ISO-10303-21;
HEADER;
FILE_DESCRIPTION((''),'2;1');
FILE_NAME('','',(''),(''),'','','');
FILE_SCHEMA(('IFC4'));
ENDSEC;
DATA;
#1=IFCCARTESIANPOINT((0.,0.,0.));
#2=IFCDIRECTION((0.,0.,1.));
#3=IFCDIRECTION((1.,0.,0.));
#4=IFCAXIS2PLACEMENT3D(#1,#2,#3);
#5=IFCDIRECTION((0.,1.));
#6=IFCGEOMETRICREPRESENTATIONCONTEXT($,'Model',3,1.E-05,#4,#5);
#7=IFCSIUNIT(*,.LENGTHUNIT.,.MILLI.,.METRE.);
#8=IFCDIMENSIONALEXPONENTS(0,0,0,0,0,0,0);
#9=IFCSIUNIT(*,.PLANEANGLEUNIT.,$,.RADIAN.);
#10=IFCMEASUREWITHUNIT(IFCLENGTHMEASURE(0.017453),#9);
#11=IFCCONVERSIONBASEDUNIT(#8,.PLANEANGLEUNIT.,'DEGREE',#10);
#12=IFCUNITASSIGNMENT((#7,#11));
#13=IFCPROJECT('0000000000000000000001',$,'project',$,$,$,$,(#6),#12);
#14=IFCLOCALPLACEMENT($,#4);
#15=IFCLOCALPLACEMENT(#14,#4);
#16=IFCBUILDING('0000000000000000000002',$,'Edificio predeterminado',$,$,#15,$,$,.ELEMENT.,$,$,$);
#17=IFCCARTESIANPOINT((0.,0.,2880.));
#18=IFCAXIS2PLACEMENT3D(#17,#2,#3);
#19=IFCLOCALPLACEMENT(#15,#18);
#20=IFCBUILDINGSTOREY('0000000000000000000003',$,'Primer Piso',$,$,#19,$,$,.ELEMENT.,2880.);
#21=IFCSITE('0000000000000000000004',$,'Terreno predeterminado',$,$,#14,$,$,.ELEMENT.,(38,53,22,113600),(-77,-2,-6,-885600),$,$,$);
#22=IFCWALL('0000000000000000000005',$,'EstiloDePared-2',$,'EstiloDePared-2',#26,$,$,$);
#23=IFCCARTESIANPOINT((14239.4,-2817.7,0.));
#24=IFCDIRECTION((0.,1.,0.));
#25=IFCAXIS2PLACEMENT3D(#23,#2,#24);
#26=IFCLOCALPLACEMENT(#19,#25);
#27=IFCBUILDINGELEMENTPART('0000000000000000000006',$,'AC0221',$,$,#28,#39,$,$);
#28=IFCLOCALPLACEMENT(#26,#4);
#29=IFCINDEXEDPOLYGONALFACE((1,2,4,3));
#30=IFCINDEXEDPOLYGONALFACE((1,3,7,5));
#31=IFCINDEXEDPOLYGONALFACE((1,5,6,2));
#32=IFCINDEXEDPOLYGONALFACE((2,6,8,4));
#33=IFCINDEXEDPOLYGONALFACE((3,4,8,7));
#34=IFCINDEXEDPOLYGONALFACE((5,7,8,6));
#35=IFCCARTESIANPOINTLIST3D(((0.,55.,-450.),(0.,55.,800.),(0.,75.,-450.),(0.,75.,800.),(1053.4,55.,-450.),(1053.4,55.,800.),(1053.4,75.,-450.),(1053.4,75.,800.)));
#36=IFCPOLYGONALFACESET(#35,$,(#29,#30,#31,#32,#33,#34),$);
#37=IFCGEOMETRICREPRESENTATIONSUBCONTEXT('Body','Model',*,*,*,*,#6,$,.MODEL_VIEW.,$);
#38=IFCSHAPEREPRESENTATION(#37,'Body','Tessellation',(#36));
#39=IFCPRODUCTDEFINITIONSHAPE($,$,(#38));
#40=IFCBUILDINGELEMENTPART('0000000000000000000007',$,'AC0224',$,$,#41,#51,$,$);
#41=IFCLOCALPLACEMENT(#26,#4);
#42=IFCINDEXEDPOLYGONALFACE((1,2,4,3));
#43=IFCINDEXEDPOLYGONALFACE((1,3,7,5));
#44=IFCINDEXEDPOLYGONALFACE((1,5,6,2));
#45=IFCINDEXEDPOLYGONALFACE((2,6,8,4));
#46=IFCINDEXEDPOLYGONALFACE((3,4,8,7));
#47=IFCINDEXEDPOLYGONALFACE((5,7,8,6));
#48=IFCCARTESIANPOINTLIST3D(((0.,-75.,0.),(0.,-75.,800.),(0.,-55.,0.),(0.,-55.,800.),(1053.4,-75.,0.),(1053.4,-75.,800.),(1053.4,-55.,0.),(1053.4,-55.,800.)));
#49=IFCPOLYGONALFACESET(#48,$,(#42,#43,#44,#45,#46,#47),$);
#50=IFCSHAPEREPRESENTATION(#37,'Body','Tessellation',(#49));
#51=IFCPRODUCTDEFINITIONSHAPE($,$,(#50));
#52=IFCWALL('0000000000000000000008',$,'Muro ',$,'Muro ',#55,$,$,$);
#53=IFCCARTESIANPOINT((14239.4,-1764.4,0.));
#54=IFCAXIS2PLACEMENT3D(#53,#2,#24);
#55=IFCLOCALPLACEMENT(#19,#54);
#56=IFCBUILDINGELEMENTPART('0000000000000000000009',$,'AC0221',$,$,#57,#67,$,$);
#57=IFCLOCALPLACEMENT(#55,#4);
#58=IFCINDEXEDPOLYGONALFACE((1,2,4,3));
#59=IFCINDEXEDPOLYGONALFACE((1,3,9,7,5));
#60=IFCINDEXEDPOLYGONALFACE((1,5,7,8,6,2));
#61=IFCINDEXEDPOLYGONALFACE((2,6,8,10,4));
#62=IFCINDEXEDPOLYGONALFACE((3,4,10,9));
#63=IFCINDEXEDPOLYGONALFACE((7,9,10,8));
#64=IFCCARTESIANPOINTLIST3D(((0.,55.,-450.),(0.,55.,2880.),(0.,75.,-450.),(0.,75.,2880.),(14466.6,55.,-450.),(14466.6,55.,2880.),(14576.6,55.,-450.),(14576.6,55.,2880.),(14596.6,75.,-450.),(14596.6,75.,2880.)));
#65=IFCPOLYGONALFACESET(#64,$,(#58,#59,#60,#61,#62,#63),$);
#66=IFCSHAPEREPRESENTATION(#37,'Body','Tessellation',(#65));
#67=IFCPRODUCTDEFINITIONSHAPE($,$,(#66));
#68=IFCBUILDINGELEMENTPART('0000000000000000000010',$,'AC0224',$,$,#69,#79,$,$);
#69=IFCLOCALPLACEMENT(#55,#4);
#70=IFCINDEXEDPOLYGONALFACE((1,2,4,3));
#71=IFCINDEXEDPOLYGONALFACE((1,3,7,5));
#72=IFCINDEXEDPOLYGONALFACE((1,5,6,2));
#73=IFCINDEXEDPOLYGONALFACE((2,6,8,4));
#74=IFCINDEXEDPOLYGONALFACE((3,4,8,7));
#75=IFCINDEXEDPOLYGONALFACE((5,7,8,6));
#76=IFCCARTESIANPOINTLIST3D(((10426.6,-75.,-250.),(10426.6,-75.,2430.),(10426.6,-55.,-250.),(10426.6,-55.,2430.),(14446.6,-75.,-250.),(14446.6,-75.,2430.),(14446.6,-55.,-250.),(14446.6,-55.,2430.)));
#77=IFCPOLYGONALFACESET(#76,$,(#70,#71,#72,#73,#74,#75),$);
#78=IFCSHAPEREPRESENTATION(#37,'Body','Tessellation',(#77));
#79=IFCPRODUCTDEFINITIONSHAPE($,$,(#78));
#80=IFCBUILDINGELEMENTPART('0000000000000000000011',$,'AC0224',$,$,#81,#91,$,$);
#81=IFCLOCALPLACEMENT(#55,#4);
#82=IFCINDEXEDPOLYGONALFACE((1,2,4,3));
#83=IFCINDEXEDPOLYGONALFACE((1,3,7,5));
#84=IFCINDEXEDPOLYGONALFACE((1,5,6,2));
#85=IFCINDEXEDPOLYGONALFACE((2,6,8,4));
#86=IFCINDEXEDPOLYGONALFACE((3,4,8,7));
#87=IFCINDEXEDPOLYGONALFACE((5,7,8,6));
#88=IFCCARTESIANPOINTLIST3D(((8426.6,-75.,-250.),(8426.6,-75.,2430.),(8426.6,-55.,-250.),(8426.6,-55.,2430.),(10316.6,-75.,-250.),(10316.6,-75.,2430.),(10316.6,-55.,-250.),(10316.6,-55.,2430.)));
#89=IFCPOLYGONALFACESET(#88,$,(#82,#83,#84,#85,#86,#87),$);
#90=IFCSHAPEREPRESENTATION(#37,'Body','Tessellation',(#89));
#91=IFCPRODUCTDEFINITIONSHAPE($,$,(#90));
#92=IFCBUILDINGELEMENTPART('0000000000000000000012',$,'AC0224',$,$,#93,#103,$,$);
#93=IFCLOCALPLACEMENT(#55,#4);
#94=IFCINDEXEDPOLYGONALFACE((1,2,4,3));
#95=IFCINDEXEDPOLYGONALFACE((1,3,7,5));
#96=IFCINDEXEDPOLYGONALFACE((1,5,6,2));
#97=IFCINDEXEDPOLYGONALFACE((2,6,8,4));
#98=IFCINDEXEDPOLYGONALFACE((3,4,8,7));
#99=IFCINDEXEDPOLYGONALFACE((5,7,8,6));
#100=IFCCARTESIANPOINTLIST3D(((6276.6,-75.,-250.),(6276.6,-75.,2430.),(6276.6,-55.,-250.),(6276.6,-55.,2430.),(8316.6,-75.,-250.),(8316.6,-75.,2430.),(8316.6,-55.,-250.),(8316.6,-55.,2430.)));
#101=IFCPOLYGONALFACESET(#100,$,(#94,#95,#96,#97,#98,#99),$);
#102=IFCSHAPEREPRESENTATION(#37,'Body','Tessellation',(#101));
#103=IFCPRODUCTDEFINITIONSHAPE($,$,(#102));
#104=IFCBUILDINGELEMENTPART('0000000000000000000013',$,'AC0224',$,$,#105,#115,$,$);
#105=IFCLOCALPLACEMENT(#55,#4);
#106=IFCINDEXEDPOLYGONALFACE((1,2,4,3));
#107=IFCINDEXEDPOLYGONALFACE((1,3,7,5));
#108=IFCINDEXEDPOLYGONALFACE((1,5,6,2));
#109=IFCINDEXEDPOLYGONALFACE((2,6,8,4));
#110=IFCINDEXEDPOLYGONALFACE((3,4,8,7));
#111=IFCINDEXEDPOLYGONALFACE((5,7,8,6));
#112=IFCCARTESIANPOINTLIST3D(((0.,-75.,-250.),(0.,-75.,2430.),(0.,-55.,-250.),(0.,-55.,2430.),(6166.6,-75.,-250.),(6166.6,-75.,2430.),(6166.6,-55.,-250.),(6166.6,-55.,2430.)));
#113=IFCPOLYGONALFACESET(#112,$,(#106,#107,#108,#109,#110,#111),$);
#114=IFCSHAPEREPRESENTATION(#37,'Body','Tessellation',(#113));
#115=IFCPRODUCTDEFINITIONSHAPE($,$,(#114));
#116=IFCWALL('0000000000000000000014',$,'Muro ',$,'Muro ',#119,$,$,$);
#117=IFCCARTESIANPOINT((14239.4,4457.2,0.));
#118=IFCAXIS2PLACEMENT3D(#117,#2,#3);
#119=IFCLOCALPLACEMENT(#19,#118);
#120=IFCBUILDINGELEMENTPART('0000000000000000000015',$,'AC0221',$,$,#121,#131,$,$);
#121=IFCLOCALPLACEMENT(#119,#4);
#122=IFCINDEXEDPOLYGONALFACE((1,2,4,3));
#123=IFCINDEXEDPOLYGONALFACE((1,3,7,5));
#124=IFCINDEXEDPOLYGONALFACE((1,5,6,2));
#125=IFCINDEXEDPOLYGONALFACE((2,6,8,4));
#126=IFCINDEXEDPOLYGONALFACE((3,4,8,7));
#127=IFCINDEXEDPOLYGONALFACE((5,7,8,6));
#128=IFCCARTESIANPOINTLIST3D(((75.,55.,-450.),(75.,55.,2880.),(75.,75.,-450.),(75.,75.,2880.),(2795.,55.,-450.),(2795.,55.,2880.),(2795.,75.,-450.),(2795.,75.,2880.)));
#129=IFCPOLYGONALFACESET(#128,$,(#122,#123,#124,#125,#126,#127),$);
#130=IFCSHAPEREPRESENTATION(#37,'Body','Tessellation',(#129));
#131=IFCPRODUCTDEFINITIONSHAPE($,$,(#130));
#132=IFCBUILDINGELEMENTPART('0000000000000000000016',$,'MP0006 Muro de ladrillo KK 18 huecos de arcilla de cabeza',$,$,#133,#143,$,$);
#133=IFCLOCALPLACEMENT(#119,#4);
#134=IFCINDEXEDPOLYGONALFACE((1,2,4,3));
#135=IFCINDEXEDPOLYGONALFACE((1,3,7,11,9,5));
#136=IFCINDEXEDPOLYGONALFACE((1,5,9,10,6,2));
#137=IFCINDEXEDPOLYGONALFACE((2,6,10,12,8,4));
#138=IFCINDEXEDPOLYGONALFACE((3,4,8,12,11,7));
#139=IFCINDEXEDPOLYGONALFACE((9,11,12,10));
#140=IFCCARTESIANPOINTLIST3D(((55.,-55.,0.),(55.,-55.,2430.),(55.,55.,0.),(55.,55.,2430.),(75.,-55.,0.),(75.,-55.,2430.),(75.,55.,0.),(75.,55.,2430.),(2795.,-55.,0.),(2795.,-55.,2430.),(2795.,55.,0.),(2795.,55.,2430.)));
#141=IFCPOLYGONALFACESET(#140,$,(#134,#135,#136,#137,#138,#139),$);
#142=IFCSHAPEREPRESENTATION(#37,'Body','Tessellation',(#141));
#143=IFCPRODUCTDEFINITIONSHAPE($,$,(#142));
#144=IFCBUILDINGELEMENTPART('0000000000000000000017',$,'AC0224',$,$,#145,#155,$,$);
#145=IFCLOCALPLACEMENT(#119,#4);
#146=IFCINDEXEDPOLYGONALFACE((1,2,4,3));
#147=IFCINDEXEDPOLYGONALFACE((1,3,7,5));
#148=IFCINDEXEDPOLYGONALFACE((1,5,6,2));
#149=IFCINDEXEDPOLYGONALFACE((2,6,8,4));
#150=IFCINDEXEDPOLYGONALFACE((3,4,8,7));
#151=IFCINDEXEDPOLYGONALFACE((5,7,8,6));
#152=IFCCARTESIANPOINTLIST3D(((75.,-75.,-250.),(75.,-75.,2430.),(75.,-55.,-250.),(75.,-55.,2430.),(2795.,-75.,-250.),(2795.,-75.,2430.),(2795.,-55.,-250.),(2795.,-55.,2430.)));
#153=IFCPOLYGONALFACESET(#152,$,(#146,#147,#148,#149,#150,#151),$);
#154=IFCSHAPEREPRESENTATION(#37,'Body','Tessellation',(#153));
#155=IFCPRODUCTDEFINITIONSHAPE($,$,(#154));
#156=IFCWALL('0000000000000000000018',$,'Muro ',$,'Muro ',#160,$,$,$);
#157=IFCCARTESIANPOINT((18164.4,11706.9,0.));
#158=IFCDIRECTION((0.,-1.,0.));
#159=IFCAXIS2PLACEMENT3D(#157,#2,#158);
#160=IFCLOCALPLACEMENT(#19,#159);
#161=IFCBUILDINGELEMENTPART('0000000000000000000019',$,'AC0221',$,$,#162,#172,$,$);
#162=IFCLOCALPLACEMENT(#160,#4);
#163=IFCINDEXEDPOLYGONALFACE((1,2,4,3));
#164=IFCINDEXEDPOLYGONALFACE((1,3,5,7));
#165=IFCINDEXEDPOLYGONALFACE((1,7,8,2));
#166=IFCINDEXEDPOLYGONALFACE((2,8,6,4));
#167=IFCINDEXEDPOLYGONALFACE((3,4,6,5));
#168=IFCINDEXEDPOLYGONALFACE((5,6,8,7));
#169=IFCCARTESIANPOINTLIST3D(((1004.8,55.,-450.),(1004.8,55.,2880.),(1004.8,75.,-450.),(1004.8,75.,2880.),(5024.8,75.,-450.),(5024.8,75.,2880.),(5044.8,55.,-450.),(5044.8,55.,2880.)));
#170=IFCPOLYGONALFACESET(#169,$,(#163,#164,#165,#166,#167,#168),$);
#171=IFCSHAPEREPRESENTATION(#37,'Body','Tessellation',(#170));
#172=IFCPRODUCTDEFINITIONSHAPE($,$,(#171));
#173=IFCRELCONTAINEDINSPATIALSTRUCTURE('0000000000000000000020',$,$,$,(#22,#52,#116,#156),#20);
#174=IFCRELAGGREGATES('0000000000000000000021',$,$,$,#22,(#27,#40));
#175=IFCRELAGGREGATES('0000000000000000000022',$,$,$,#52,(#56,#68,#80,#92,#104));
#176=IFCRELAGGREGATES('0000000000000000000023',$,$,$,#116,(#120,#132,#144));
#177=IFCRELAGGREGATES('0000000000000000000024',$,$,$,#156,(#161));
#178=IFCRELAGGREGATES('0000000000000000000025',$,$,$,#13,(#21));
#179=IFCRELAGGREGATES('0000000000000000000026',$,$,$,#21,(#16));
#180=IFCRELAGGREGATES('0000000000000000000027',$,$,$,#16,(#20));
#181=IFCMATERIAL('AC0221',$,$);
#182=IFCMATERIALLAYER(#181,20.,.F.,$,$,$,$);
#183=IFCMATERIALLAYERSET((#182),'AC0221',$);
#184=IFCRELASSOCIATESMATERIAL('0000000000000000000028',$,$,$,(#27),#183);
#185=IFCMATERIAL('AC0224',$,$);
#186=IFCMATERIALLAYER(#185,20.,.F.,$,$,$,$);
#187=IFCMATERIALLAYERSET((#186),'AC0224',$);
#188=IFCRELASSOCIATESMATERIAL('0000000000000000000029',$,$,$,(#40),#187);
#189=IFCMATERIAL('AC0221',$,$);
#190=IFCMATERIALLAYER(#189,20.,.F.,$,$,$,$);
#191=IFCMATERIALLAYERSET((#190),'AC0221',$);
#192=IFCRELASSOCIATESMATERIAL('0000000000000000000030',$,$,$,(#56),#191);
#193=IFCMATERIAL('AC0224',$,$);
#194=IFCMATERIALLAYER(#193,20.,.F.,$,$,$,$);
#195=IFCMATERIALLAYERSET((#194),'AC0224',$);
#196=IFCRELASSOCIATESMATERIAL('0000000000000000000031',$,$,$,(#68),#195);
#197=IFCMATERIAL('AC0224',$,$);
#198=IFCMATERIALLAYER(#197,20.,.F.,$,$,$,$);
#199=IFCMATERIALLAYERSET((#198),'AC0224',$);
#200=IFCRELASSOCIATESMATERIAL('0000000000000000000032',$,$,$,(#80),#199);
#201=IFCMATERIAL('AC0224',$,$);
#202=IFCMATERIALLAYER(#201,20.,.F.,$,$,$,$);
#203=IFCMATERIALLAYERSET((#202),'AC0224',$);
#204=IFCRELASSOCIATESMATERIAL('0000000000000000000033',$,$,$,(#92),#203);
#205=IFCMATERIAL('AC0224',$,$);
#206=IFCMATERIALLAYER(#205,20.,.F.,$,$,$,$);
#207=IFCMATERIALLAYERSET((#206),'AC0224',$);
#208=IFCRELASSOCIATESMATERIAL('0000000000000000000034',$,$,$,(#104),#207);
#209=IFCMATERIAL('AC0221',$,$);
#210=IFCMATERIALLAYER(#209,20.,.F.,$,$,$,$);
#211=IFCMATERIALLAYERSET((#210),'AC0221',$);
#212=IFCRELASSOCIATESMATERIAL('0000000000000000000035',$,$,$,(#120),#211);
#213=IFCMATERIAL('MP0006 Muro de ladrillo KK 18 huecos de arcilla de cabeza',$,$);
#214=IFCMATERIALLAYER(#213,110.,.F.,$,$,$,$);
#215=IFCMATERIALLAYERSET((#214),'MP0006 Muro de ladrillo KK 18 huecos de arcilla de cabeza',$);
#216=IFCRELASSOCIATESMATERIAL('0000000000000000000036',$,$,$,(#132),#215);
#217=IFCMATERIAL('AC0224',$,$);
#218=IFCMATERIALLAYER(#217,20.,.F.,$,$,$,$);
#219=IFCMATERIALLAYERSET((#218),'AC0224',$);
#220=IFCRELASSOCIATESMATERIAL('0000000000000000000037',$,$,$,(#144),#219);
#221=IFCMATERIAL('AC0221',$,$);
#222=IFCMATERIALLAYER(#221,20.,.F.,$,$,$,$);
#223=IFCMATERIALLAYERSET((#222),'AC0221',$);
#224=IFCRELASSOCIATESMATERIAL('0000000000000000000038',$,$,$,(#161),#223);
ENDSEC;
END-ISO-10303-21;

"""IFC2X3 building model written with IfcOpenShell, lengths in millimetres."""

from ifc_helpers import new_model, entity, si_unit, converted_unit, direction, frame, origin_with_axes, place, context, subcontext, project, spatial, polyline, outline, extrude, material, layer, layer_set, layer_usage, element, aggregate, save


model = new_model("IFC2X3")

# Units and contexts
model_context = context("Model", 3, precision=1e-05, world=origin_with_axes(), true_north=direction((0.0, 1.0)))
body_context = subcontext(model_context, "Body", "Model", "MODEL_VIEW")
ifc_project = project(units=[si_unit("LENGTHUNIT", "METRE", prefix="MILLI"), converted_unit("PLANEANGLEUNIT", "DEGREE", entity("IfcLengthMeasure", 0.017453), si_unit("PLANEANGLEUNIT", "RADIAN"), dimensions=[0, 0, 0, 0, 0, 0, 0])], contexts=[model_context])

# Site, building, storey
site_placement = place(None, origin_with_axes())
site = spatial("IfcSite", under=ifc_project, at=site_placement, Name="Terreno predeterminado", CompositionType="ELEMENT", RefLatitude=(38, 53, 22, 113600), RefLongitude=(-77, -2, -6, -885600))
building_placement = place(site_placement, origin_with_axes())
building = spatial("IfcBuilding", under=site, at=building_placement, Name="Edificio predeterminado", CompositionType="ELEMENT")
storey_placement = place(building_placement, frame((0.0, 0.0, 2880.0), z_axis=(0.0, 0.0, 1.0), x_axis=(1.0, 0.0, 0.0)))
storey = spatial("IfcBuildingStorey", under=building, at=storey_placement, Name="Primer Piso", CompositionType="ELEMENT", Elevation=2880.0)

# Walls, building element parts
wall_1_placement = place(storey_placement, frame((14239.4, -2817.7, 0.0), z_axis=(0.0, 0.0, 1.0), x_axis=(0.0, 1.0, 0.0)))
wall_1 = element("IfcWall", 1, at=wall_1_placement, inside=storey, Name="EstiloDePared-2", ObjectType="EstiloDePared-2")
ifc_material_1 = material(Name="AC0221")
ifc_layer_1 = layer(ifc_material_1, 20.0, ventilated=False)
ifc_layer_set_1 = layer_set([ifc_layer_1], Name="AC0221")
ifc_layer_usage_1 = layer_usage(ifc_layer_set_1, "AXIS2", "NEGATIVE", -75.0)
building_element_part_1_placement = place(wall_1_placement, origin_with_axes())
building_element_part_1 = element("IfcBuildingElementPart", 2, at=building_element_part_1_placement, material=ifc_layer_usage_1, Name="AC0221", context=body_context, shape_type="SweptSolid", body=[
    extrude(outline(polyline([(1053.4, 75.0), (1053.4, 55.0), (0.0, 55.0), (0.0, 75.0), (1053.4, 75.0)])), frame((0.0, 0.0, -450.0), z_axis=(0.0, 0.0, 1.0), x_axis=(1.0, 0.0, 0.0)), (0.0, 0.0, 1.0), 1250.0),
])
ifc_material_2 = material(Name="AC0224")
ifc_layer_2 = layer(ifc_material_2, 20.0, ventilated=False)
ifc_layer_set_2 = layer_set([ifc_layer_2], Name="AC0224")
ifc_layer_usage_2 = layer_usage(ifc_layer_set_2, "AXIS2", "NEGATIVE", 55.0)
building_element_part_2_placement = place(wall_1_placement, origin_with_axes())
building_element_part_2 = element("IfcBuildingElementPart", 3, at=building_element_part_2_placement, material=ifc_layer_usage_2, Name="AC0224", context=body_context, shape_type="SweptSolid", body=[
    extrude(outline(polyline([(1053.4, -55.0), (1053.4, -75.0), (0.0, -75.0), (0.0, -55.0), (1053.4, -55.0)])), origin_with_axes(), (0.0, 0.0, 1.0), 800.0),
])
aggregate(wall_1, [building_element_part_1, building_element_part_2])
wall_2_placement = place(storey_placement, frame((14239.4, -1764.4, 0.0), z_axis=(0.0, 0.0, 1.0), x_axis=(0.0, 1.0, 0.0)))
wall_2 = element("IfcWall", 4, at=wall_2_placement, inside=storey, Name="Muro ", ObjectType="Muro ")
ifc_material_3 = material(Name="AC0221")
ifc_layer_3 = layer(ifc_material_3, 20.0, ventilated=False)
ifc_layer_set_3 = layer_set([ifc_layer_3], Name="AC0221")
ifc_layer_usage_3 = layer_usage(ifc_layer_set_3, "AXIS2", "NEGATIVE", -75.0)
building_element_part_3_placement = place(wall_2_placement, origin_with_axes())
building_element_part_3 = element("IfcBuildingElementPart", 5, at=building_element_part_3_placement, material=ifc_layer_usage_3, Name="AC0221", context=body_context, shape_type="SweptSolid", body=[
    extrude(outline(polyline([(14596.6, 75.0), (14576.6, 55.0), (14466.6, 55.0), (0.0, 55.0), (0.0, 75.0), (14596.6, 75.0)])), frame((0.0, 0.0, -450.0), z_axis=(0.0, 0.0, 1.0), x_axis=(1.0, 0.0, 0.0)), (0.0, 0.0, 1.0), 3330.0),
])
ifc_material_4 = material(Name="AC0224")
ifc_layer_4 = layer(ifc_material_4, 20.0, ventilated=False)
ifc_layer_set_4 = layer_set([ifc_layer_4], Name="AC0224")
ifc_layer_usage_4 = layer_usage(ifc_layer_set_4, "AXIS2", "NEGATIVE", 55.0)
building_element_part_4_placement = place(wall_2_placement, origin_with_axes())
building_element_part_4 = element("IfcBuildingElementPart", 6, at=building_element_part_4_placement, material=ifc_layer_usage_4, Name="AC0224", context=body_context, shape_type="SweptSolid", body=[
    extrude(outline(polyline([(14446.6, -55.0), (14446.6, -75.0), (10426.6, -75.0), (10426.6, -55.0), (14446.6, -55.0)])), frame((0.0, 0.0, -250.0), z_axis=(0.0, 0.0, 1.0), x_axis=(1.0, 0.0, 0.0)), (0.0, 0.0, 1.0), 2680.0),
])
ifc_material_5 = material(Name="AC0224")
ifc_layer_5 = layer(ifc_material_5, 20.0, ventilated=False)
ifc_layer_set_5 = layer_set([ifc_layer_5], Name="AC0224")
ifc_layer_usage_5 = layer_usage(ifc_layer_set_5, "AXIS2", "NEGATIVE", 55.0)
building_element_part_5_placement = place(wall_2_placement, origin_with_axes())
building_element_part_5 = element("IfcBuildingElementPart", 7, at=building_element_part_5_placement, material=ifc_layer_usage_5, Name="AC0224", context=body_context, shape_type="SweptSolid", body=[
    extrude(outline(polyline([(10316.6, -55.0), (10316.6, -75.0), (8426.6, -75.0), (8426.6, -55.0), (10316.6, -55.0)])), frame((0.0, 0.0, -250.0), z_axis=(0.0, 0.0, 1.0), x_axis=(1.0, 0.0, 0.0)), (0.0, 0.0, 1.0), 2680.0),
])
ifc_material_6 = material(Name="AC0224")
ifc_layer_6 = layer(ifc_material_6, 20.0, ventilated=False)
ifc_layer_set_6 = layer_set([ifc_layer_6], Name="AC0224")
ifc_layer_usage_6 = layer_usage(ifc_layer_set_6, "AXIS2", "NEGATIVE", 55.0)
building_element_part_6_placement = place(wall_2_placement, origin_with_axes())
building_element_part_6 = element("IfcBuildingElementPart", 8, at=building_element_part_6_placement, material=ifc_layer_usage_6, Name="AC0224", context=body_context, shape_type="SweptSolid", body=[
    extrude(outline(polyline([(8316.6, -55.0), (8316.6, -75.0), (6276.6, -75.0), (6276.6, -55.0), (8316.6, -55.0)])), frame((0.0, 0.0, -250.0), z_axis=(0.0, 0.0, 1.0), x_axis=(1.0, 0.0, 0.0)), (0.0, 0.0, 1.0), 2680.0),
])
ifc_material_7 = material(Name="AC0224")
ifc_layer_7 = layer(ifc_material_7, 20.0, ventilated=False)
ifc_layer_set_7 = layer_set([ifc_layer_7], Name="AC0224")
ifc_layer_usage_7 = layer_usage(ifc_layer_set_7, "AXIS2", "NEGATIVE", 55.0)
building_element_part_7_placement = place(wall_2_placement, origin_with_axes())
building_element_part_7 = element("IfcBuildingElementPart", 9, at=building_element_part_7_placement, material=ifc_layer_usage_7, Name="AC0224", context=body_context, shape_type="SweptSolid", body=[
    extrude(outline(polyline([(6166.6, -55.0), (6166.6, -75.0), (0.0, -75.0), (0.0, -55.0), (6166.6, -55.0)])), frame((0.0, 0.0, -250.0), z_axis=(0.0, 0.0, 1.0), x_axis=(1.0, 0.0, 0.0)), (0.0, 0.0, 1.0), 2680.0),
])
aggregate(wall_2, [building_element_part_3, building_element_part_4, building_element_part_5, building_element_part_6, building_element_part_7])
wall_3_placement = place(storey_placement, frame((14239.4, 4457.2, 0.0), z_axis=(0.0, 0.0, 1.0), x_axis=(1.0, 0.0, 0.0)))
wall_3 = element("IfcWall", 10, at=wall_3_placement, inside=storey, Name="Muro ", ObjectType="Muro ")
ifc_material_8 = material(Name="AC0221")
ifc_layer_8 = layer(ifc_material_8, 20.0, ventilated=False)
ifc_layer_set_8 = layer_set([ifc_layer_8], Name="AC0221")
ifc_layer_usage_8 = layer_usage(ifc_layer_set_8, "AXIS2", "NEGATIVE", -75.0)
building_element_part_8_placement = place(wall_3_placement, origin_with_axes())
building_element_part_8 = element("IfcBuildingElementPart", 11, at=building_element_part_8_placement, material=ifc_layer_usage_8, Name="AC0221", context=body_context, shape_type="SweptSolid", body=[
    extrude(outline(polyline([(2795.0, 75.0), (2795.0, 55.0), (75.0, 55.0), (75.0, 75.0), (2795.0, 75.0)])), frame((0.0, 0.0, -450.0), z_axis=(0.0, 0.0, 1.0), x_axis=(1.0, 0.0, 0.0)), (0.0, 0.0, 1.0), 3330.0),
])
ifc_material_9 = material(Name="MP0006 Muro de ladrillo KK 18 huecos de arcilla de cabeza")
ifc_layer_9 = layer(ifc_material_9, 110.0, ventilated=False)
ifc_layer_set_9 = layer_set([ifc_layer_9], Name="MP0006 Muro de ladrillo KK 18 huecos de arcilla de cabeza")
ifc_layer_usage_9 = layer_usage(ifc_layer_set_9, "AXIS2", "NEGATIVE", -55.0)
building_element_part_9_placement = place(wall_3_placement, origin_with_axes())
building_element_part_9 = element("IfcBuildingElementPart", 12, at=building_element_part_9_placement, material=ifc_layer_usage_9, Name="MP0006 Muro de ladrillo KK 18 huecos de arcilla de cabeza", context=body_context, shape_type="SweptSolid", body=[
    extrude(outline(polyline([(2795.0, 55.0), (2795.0, -55.0), (75.0, -55.0), (55.0, -55.0), (55.0, 55.0), (75.0, 55.0), (2795.0, 55.0)])), origin_with_axes(), (0.0, 0.0, 1.0), 2430.0),
])
ifc_material_10 = material(Name="AC0224")
ifc_layer_10 = layer(ifc_material_10, 20.0, ventilated=False)
ifc_layer_set_10 = layer_set([ifc_layer_10], Name="AC0224")
ifc_layer_usage_10 = layer_usage(ifc_layer_set_10, "AXIS2", "NEGATIVE", 55.0)
building_element_part_10_placement = place(wall_3_placement, origin_with_axes())
building_element_part_10 = element("IfcBuildingElementPart", 13, at=building_element_part_10_placement, material=ifc_layer_usage_10, Name="AC0224", context=body_context, shape_type="SweptSolid", body=[
    extrude(outline(polyline([(75.0, -55.0), (2795.0, -55.0), (2795.0, -75.0), (75.0, -75.0), (75.0, -55.0)])), frame((0.0, 0.0, -250.0), z_axis=(0.0, 0.0, 1.0), x_axis=(1.0, 0.0, 0.0)), (0.0, 0.0, 1.0), 2680.0),
])
aggregate(wall_3, [building_element_part_8, building_element_part_9, building_element_part_10])
wall_4_placement = place(storey_placement, frame((18164.4, 11706.9, 0.0), z_axis=(0.0, 0.0, 1.0), x_axis=(0.0, -1.0, 0.0)))
wall_4 = element("IfcWall", 14, at=wall_4_placement, inside=storey, Name="Muro ", ObjectType="Muro ")
ifc_material_11 = material(Name="AC0221")
ifc_layer_11 = layer(ifc_material_11, 20.0, ventilated=False)
ifc_layer_set_11 = layer_set([ifc_layer_11], Name="AC0221")
ifc_layer_usage_11 = layer_usage(ifc_layer_set_11, "AXIS2", "NEGATIVE", -75.0)
building_element_part_11_placement = place(wall_4_placement, origin_with_axes())
building_element_part_11 = element("IfcBuildingElementPart", 15, at=building_element_part_11_placement, material=ifc_layer_usage_11, Name="AC0221", context=body_context, shape_type="SweptSolid", body=[
    extrude(outline(polyline([(5024.8, 75.0), (5044.8, 55.0), (1004.8, 55.0), (1004.8, 75.0), (5024.8, 75.0)])), frame((0.0, 0.0, -450.0), z_axis=(0.0, 0.0, 1.0), x_axis=(1.0, 0.0, 0.0)), (0.0, 0.0, 1.0), 3330.0),
])
aggregate(wall_4, [building_element_part_11])

save(model, "model.ifc")
